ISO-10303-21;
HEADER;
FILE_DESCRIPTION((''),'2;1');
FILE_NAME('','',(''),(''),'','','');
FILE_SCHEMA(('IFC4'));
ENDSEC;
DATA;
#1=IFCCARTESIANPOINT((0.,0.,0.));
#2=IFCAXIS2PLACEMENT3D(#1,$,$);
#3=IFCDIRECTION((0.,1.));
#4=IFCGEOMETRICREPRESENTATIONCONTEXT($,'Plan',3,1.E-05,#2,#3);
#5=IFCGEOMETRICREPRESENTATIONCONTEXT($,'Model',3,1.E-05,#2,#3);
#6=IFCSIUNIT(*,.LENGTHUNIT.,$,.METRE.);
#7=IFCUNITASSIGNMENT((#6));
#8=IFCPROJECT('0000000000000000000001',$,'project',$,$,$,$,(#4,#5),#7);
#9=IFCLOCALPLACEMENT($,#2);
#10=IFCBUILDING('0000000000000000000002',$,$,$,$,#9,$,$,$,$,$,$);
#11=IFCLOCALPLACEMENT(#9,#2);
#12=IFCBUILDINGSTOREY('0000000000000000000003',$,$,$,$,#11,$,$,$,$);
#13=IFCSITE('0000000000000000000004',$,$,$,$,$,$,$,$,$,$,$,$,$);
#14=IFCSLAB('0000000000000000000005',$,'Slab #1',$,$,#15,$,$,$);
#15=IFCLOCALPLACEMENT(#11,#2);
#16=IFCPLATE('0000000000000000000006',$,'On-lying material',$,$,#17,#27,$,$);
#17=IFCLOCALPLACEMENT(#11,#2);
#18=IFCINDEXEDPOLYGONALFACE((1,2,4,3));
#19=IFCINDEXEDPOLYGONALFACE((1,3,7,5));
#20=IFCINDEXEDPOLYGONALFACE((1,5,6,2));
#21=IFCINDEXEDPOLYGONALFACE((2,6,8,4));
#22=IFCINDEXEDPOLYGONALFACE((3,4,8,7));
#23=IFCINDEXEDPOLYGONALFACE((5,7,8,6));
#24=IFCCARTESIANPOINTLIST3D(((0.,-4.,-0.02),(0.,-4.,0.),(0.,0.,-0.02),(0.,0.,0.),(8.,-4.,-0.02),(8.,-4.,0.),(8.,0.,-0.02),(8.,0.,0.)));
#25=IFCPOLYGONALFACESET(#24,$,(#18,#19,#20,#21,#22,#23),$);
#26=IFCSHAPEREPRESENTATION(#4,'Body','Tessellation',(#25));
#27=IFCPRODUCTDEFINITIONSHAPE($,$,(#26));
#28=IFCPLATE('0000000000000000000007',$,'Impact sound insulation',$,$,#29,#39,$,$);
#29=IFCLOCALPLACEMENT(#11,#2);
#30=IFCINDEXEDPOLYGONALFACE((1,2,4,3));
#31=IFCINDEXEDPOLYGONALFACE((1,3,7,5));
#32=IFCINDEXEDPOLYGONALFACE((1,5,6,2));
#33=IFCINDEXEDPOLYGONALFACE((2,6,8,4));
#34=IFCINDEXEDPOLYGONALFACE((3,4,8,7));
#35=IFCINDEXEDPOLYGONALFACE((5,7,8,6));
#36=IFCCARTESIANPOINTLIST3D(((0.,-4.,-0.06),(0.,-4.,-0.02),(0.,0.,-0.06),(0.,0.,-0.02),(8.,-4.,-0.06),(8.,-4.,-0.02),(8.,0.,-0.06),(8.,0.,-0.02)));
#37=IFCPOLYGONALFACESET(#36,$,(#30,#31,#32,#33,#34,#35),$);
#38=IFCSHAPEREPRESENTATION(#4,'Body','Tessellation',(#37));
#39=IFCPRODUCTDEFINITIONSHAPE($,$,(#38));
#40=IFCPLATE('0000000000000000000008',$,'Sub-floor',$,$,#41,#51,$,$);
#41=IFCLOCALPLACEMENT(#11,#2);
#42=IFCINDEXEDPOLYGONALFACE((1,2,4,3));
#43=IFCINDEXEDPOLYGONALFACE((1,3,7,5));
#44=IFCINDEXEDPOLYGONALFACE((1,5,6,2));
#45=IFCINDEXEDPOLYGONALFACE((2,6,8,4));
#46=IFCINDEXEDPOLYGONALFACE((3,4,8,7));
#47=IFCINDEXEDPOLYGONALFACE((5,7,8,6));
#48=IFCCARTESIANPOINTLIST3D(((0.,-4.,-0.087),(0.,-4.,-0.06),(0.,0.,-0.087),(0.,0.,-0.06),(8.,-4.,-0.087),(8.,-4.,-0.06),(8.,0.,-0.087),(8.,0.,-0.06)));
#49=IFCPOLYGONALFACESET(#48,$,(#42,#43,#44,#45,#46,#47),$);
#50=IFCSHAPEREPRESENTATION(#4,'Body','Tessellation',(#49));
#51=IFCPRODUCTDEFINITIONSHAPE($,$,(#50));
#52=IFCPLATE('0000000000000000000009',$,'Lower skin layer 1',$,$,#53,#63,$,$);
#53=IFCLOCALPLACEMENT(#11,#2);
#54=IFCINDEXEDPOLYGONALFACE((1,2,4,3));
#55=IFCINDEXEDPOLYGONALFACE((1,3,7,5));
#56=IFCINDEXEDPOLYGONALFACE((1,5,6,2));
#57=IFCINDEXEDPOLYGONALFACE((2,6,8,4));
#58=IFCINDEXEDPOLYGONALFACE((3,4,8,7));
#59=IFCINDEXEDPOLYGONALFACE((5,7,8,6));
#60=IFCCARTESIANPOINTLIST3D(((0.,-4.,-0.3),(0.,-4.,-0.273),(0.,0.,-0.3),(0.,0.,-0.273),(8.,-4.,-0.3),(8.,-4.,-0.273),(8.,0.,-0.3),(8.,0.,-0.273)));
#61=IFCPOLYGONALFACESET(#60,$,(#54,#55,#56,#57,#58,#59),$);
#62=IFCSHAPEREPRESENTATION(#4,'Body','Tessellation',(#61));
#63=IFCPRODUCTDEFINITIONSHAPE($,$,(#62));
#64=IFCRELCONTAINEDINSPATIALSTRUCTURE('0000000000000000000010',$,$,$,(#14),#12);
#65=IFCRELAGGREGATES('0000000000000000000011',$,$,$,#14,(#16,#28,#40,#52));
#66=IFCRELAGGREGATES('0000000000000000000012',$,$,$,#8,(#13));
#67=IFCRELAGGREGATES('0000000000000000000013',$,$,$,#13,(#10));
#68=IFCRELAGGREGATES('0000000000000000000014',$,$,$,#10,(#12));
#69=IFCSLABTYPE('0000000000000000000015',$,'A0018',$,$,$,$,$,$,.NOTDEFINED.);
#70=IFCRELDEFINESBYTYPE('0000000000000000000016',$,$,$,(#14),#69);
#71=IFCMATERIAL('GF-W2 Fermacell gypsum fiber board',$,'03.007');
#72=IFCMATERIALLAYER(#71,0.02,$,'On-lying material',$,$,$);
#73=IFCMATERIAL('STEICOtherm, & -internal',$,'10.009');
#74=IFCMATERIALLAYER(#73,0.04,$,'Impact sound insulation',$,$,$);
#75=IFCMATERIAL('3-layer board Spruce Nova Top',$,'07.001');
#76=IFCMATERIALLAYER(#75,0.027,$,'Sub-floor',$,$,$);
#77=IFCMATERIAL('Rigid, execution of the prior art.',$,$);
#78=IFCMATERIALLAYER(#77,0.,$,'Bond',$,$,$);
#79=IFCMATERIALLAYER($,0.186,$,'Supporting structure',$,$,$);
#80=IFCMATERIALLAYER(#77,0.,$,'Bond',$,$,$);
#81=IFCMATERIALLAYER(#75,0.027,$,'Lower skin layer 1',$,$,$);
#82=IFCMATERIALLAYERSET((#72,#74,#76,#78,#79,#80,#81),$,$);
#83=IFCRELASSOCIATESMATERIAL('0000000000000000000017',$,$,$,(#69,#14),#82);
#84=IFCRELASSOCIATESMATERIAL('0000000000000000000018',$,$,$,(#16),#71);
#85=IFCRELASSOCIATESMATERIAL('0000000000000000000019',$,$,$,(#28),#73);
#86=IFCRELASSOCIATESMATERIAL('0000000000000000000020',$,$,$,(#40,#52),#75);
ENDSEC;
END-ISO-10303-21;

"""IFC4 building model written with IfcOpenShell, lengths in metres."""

from ifc_helpers import new_model, si_unit, direction, frame, frame_2d, origin, origin_with_axes, place, context, project, spatial, rectangle, extrude, material, layer, layer_set, type_object, element, aggregate, save


model = new_model("IFC4")

# Units and contexts
plan_context = context("Plan", 3, precision=1e-05, world=origin(), true_north=direction((0.0, 1.0)))
model_context = context("Model", 3, precision=1e-05, world=origin(), true_north=direction((0.0, 1.0)))
ifc_project = project(units=[si_unit("LENGTHUNIT", "METRE")], contexts=[plan_context, model_context])

# Site, building, storey
site = spatial("IfcSite", under=ifc_project)
building_placement = place(None, origin())
building = spatial("IfcBuilding", under=site, at=building_placement)
storey_placement = place(building_placement, origin())
storey = spatial("IfcBuildingStorey", under=building, at=storey_placement)

# Slab, plates
ifc_material_1 = material(Name="GF-W2 Fermacell gypsum fiber board", Category="03.007")
ifc_layer_1 = layer(ifc_material_1, 0.02, Name="On-lying material")
ifc_material_2 = material(Name="STEICOtherm, & -internal", Category="10.009")
ifc_layer_2 = layer(ifc_material_2, 0.04, Name="Impact sound insulation")
ifc_material_3 = material(Name="3-layer board Spruce Nova Top", Category="07.001")
ifc_layer_3 = layer(ifc_material_3, 0.027, Name="Sub-floor")
ifc_material_4 = material(Name="Rigid, execution of the prior art.")
ifc_layer_4 = layer(ifc_material_4, 0.0, Name="Bond")
ifc_layer_5 = layer(None, 0.186, Name="Supporting structure")
ifc_layer_6 = layer(ifc_material_4, 0.0, Name="Bond")
ifc_layer_7 = layer(ifc_material_3, 0.027, Name="Lower skin layer 1")
ifc_layer_set = layer_set([ifc_layer_1, ifc_layer_2, ifc_layer_3, ifc_layer_4, ifc_layer_5, ifc_layer_6, ifc_layer_7])
slab_type = type_object("IfcSlabType", Name="A0018", PredefinedType="NOTDEFINED", material=ifc_layer_set)
slab_placement = place(None, frame((0.0, 0.0, 0.0), z_axis=(0.0, 0.0, -1.0), x_axis=(1.0, 0.0, 0.0)))
slab = element("IfcSlab", 1, at=slab_placement, inside=storey, type_object=slab_type, material=ifc_layer_set, Name="Slab #1")
plate_1_placement = place(slab_placement, origin())
plate_1 = element("IfcPlate", 2, at=plate_1_placement, material=ifc_material_1, Name="On-lying material", context=plan_context, shape_type="SweptSolid", body=[
    extrude(rectangle(XDim=8.0, YDim=4.0, at=frame_2d((4.0, 2.0), x_axis=(1.0, 0.0))), origin_with_axes(), (0.0, 0.0, 1.0), 0.02),
])
plate_2_placement = place(slab_placement, origin())
plate_2 = element("IfcPlate", 3, at=plate_2_placement, material=ifc_material_2, Name="Impact sound insulation", context=plan_context, shape_type="SweptSolid", body=[
    extrude(rectangle(XDim=8.0, YDim=4.0, at=frame_2d((4.0, 2.0), x_axis=(1.0, 0.0))), frame((0.0, 0.0, 0.02), z_axis=(0.0, 0.0, 1.0), x_axis=(1.0, 0.0, 0.0)), (0.0, 0.0, 1.0), 0.04),
])
plate_3_placement = place(slab_placement, origin())
plate_3 = element("IfcPlate", 4, at=plate_3_placement, material=ifc_material_3, Name="Sub-floor", context=plan_context, shape_type="SweptSolid", body=[
    extrude(rectangle(XDim=8.0, YDim=4.0, at=frame_2d((4.0, 2.0), x_axis=(1.0, 0.0))), frame((0.0, 0.0, 0.06), z_axis=(0.0, 0.0, 1.0), x_axis=(1.0, 0.0, 0.0)), (0.0, 0.0, 1.0), 0.027),
])
plate_4_placement = place(slab_placement, origin())
plate_4 = element("IfcPlate", 5, at=plate_4_placement, material=ifc_material_3, Name="Lower skin layer 1", context=plan_context, shape_type="SweptSolid", body=[
    extrude(rectangle(XDim=8.0, YDim=4.0, at=frame_2d((4.0, 2.0), x_axis=(1.0, 0.0))), frame((0.0, 0.0, 0.273), z_axis=(0.0, 0.0, 1.0), x_axis=(1.0, 0.0, 0.0)), (0.0, 0.0, 1.0), 0.027),
])
aggregate(slab, [plate_1, plate_2, plate_3, plate_4])

save(model, "model.ifc")
